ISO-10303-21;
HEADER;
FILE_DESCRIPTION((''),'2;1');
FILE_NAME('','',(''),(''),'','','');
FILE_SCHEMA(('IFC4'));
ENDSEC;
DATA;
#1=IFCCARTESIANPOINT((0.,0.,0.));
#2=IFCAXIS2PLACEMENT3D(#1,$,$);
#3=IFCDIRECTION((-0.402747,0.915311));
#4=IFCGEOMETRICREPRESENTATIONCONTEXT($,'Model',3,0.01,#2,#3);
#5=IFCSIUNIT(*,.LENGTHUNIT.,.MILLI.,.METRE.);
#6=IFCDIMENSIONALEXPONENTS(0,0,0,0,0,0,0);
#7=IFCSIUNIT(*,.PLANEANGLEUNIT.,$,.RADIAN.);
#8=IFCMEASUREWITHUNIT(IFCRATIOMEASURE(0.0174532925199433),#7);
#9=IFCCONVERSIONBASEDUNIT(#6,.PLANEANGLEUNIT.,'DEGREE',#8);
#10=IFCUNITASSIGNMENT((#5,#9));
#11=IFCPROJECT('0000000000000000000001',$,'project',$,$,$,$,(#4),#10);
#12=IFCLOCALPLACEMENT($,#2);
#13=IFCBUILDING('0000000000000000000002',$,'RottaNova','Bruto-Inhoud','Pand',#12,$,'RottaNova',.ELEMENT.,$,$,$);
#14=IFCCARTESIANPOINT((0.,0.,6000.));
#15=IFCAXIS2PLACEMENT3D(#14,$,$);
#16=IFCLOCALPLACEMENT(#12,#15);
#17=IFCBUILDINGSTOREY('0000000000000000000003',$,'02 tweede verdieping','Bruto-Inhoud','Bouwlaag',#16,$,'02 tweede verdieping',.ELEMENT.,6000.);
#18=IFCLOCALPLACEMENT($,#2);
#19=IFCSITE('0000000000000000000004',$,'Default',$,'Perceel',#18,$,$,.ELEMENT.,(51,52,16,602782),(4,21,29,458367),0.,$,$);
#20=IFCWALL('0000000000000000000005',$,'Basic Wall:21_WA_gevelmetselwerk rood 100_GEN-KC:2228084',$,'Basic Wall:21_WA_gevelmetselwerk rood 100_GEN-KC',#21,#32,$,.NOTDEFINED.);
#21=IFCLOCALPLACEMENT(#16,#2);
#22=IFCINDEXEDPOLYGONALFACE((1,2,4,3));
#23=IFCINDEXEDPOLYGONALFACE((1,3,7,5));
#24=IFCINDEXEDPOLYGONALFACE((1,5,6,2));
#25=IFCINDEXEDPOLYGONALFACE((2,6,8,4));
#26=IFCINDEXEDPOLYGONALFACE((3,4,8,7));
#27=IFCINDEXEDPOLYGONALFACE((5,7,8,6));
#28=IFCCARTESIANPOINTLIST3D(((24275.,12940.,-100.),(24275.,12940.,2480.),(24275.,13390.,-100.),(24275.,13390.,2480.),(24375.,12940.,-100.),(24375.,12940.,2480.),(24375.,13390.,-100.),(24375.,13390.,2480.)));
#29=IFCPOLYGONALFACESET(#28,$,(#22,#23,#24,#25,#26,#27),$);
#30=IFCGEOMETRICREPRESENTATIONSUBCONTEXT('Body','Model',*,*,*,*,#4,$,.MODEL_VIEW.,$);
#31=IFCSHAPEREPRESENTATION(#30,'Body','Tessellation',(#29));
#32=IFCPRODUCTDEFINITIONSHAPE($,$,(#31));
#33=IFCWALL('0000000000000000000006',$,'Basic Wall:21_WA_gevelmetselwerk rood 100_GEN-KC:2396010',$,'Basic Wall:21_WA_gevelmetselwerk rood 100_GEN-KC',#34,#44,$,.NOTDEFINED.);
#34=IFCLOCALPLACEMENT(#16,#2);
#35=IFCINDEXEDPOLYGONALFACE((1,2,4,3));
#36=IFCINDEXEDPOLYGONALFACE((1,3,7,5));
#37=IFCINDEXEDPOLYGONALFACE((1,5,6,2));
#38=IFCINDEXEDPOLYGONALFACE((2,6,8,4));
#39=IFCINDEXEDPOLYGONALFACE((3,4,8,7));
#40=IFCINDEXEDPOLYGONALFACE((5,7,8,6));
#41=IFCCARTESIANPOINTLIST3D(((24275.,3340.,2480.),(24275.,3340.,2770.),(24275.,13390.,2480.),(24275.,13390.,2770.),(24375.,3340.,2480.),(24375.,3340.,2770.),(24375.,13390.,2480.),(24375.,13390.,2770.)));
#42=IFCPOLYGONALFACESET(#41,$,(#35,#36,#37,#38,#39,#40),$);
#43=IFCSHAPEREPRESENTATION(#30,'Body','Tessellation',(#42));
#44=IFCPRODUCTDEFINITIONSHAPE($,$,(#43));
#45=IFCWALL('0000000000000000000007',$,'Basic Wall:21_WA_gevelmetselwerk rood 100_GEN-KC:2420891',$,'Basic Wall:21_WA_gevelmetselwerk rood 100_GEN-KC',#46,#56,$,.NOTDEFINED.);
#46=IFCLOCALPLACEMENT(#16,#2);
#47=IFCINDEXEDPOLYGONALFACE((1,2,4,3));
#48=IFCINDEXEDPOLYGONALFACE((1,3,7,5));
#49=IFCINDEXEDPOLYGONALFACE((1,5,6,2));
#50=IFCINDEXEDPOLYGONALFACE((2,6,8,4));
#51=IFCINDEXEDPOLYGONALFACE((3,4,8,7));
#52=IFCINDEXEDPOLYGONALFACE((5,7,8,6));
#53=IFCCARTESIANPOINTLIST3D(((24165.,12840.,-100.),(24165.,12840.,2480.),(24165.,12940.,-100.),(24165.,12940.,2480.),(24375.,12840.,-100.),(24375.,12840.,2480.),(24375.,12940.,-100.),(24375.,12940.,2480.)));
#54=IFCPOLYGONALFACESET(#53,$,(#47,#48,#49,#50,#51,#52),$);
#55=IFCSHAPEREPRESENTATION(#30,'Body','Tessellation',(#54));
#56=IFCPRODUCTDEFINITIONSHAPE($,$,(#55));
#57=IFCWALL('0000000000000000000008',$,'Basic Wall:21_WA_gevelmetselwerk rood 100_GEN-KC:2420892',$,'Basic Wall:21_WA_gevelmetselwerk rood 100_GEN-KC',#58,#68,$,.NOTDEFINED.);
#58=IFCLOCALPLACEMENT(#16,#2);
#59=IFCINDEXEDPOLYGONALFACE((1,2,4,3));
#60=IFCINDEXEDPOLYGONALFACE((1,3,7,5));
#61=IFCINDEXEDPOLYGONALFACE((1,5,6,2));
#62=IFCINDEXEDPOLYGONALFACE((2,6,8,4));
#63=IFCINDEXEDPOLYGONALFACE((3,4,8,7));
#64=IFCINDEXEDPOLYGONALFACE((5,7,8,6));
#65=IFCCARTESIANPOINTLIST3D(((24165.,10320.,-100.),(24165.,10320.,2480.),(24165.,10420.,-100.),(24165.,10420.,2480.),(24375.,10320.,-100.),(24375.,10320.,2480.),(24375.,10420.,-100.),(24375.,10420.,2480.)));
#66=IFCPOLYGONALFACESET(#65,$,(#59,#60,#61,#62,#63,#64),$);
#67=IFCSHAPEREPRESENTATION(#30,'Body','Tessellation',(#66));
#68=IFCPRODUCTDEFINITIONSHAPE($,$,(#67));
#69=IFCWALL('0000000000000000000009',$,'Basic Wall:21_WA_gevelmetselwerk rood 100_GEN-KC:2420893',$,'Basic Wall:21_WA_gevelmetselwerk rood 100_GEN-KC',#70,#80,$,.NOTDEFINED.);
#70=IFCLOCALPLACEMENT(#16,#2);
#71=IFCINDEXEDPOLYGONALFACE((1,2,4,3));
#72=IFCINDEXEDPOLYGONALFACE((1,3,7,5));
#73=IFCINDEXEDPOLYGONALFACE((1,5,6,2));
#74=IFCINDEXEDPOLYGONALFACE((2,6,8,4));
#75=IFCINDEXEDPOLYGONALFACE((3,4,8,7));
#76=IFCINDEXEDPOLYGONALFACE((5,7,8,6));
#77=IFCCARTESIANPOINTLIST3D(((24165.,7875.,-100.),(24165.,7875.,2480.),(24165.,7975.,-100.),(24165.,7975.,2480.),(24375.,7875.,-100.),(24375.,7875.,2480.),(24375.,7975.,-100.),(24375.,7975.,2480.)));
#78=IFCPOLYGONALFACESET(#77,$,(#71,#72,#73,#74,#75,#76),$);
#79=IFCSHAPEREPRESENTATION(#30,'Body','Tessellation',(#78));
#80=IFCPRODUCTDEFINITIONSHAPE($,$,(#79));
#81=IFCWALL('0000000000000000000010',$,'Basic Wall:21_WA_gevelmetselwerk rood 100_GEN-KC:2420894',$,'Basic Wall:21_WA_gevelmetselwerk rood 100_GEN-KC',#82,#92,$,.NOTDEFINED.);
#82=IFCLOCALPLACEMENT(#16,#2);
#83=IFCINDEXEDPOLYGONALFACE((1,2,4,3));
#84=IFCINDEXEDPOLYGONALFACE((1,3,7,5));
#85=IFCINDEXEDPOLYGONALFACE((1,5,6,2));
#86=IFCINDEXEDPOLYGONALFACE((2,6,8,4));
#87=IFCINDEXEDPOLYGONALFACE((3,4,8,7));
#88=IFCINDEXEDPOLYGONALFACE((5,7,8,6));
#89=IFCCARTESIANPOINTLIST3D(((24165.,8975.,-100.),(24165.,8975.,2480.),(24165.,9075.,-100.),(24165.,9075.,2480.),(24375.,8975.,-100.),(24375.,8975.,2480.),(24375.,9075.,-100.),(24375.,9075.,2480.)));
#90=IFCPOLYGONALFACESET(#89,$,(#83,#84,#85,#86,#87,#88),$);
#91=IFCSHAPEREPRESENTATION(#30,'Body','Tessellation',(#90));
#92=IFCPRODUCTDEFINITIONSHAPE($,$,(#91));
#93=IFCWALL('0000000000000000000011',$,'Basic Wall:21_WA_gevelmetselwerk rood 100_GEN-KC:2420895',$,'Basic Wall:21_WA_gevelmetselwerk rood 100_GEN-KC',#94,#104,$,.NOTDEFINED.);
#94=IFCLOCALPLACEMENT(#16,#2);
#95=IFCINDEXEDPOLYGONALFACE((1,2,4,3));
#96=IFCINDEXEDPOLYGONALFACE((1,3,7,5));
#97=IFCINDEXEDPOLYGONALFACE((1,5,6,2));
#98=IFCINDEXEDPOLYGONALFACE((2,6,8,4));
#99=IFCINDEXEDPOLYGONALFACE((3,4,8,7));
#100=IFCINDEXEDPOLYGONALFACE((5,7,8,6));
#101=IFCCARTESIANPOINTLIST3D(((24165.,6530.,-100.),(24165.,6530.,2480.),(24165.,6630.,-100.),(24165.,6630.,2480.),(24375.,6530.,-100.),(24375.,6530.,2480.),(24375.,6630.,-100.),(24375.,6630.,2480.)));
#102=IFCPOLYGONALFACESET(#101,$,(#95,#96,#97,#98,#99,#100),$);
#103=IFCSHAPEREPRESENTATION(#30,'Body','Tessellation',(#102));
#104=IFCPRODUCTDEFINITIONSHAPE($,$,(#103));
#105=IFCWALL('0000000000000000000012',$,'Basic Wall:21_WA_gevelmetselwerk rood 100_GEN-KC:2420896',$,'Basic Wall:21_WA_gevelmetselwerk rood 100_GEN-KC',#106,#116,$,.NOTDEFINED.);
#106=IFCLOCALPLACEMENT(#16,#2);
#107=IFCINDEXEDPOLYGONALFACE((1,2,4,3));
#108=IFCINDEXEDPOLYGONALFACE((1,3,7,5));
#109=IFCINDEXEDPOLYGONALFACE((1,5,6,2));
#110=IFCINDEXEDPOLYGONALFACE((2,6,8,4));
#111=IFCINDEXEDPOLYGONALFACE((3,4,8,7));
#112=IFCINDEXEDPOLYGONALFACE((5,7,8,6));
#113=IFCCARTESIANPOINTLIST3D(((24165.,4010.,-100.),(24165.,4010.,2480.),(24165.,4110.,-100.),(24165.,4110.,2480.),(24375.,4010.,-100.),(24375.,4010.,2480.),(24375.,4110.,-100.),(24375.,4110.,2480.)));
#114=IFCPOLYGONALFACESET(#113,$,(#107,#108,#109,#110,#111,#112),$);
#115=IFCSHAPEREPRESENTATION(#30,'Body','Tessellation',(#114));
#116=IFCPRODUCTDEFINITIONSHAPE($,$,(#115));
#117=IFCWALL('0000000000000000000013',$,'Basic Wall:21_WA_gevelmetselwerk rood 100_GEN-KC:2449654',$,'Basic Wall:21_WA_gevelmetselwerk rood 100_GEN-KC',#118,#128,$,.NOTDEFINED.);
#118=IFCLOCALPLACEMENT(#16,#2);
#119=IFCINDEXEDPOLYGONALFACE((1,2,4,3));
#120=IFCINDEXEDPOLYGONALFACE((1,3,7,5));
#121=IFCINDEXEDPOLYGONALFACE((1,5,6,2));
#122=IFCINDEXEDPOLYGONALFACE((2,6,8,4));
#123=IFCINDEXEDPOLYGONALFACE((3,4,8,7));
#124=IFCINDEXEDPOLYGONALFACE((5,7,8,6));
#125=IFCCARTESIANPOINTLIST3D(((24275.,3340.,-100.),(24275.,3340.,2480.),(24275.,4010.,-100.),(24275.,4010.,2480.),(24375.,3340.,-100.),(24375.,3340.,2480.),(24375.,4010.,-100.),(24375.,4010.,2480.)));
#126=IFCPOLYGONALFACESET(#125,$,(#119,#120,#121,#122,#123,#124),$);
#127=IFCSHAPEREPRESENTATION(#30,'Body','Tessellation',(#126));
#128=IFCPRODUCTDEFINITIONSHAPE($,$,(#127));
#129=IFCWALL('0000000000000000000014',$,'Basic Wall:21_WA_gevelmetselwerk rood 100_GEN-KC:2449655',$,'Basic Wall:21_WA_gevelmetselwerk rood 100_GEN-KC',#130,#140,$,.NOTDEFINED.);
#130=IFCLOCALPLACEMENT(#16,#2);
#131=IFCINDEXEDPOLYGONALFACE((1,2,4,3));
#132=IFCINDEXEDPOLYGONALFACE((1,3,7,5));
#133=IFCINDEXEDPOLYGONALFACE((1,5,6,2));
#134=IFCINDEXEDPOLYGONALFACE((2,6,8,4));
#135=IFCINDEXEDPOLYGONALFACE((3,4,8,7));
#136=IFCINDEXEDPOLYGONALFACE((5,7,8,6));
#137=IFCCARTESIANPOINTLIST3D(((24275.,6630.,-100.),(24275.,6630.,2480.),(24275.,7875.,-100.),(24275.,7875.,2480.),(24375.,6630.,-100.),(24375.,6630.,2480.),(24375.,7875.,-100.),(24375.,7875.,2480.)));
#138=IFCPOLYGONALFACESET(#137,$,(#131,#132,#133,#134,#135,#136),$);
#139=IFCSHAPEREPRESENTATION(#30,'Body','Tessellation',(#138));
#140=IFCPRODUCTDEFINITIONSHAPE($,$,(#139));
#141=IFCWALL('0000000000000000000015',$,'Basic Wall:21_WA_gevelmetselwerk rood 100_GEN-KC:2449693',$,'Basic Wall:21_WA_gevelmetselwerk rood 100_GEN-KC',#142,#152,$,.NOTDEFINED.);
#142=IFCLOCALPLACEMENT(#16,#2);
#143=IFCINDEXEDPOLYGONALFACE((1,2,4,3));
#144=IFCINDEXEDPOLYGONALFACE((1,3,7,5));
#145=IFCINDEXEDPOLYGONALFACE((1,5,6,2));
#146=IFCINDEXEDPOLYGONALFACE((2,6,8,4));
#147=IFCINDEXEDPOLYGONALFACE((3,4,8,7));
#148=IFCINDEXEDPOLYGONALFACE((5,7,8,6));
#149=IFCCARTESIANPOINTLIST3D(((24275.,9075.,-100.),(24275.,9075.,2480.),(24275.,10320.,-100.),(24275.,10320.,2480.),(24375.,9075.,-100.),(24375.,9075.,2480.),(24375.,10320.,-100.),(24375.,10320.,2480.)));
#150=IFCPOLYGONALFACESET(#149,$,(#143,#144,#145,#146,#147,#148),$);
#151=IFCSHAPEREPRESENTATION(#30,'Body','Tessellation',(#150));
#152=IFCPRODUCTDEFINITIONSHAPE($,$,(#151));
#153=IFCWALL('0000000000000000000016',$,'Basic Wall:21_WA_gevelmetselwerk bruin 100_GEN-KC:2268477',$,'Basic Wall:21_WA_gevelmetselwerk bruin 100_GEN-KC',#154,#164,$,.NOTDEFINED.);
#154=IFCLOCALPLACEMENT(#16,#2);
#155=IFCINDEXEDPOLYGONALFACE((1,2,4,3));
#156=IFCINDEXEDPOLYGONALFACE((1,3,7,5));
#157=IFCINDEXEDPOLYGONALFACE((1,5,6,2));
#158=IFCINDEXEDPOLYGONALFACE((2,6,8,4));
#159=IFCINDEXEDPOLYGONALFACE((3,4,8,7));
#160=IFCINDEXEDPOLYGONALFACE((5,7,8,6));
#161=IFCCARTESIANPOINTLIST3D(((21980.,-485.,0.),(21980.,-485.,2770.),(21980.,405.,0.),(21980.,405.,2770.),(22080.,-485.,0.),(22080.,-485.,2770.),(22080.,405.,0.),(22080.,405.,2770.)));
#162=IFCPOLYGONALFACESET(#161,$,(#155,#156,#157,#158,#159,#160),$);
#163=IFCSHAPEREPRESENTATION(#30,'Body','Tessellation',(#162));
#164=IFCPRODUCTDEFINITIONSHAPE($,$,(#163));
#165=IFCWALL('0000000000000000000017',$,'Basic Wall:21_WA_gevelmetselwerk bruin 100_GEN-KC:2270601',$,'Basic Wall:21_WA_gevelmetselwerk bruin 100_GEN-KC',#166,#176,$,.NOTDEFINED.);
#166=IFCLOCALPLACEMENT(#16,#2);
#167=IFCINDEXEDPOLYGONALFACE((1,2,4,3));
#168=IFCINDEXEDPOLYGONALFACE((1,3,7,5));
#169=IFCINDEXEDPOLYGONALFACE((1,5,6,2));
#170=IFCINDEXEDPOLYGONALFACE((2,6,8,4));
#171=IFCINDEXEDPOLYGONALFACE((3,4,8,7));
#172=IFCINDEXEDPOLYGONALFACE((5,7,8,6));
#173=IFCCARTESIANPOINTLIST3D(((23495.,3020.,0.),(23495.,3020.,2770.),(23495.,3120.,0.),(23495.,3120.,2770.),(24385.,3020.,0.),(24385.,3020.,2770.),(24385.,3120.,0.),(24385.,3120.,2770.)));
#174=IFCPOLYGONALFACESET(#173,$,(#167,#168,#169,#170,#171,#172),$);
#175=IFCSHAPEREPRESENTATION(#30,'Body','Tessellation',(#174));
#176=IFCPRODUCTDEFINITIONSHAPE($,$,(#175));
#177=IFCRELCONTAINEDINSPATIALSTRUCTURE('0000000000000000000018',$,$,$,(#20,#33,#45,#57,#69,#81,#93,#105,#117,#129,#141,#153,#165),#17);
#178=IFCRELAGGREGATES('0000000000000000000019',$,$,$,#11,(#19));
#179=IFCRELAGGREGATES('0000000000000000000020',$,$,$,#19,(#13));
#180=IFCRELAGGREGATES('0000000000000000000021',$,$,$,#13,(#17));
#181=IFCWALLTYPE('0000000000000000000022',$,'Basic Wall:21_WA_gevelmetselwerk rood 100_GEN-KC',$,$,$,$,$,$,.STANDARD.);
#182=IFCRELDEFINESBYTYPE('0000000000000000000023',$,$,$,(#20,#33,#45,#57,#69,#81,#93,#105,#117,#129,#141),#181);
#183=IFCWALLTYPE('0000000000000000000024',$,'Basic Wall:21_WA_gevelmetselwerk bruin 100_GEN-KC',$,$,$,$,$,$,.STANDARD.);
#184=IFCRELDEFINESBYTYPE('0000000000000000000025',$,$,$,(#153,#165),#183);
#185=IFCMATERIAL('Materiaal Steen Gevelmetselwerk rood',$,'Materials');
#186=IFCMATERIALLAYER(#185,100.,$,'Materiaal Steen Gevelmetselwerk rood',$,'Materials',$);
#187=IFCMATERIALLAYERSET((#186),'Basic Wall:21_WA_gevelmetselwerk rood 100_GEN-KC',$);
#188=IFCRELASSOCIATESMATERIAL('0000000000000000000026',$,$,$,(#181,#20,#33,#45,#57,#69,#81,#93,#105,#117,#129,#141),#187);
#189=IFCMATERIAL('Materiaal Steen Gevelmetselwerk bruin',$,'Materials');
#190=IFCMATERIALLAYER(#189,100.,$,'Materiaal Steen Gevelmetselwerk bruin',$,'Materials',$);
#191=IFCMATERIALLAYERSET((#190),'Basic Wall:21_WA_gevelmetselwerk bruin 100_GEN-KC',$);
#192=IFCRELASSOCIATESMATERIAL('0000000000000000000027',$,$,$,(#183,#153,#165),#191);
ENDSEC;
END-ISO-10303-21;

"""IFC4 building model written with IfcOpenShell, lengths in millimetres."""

from ifc_helpers import new_model, entity, si_unit, converted_unit, direction, frame, frame_2d, origin, place, context, subcontext, project, spatial, rectangle, extrude, material, layer, layer_set, type_object, element, save


model = new_model("IFC4")

# Units and contexts
model_context = context("Model", 3, precision=0.01, world=origin(), true_north=direction((-0.402747, 0.915311)))
body_context = subcontext(model_context, "Body", "Model", "MODEL_VIEW")
ifc_project = project(units=[si_unit("LENGTHUNIT", "METRE", prefix="MILLI"), converted_unit("PLANEANGLEUNIT", "DEGREE", entity("IfcRatioMeasure", 0.0174532925199433), si_unit("PLANEANGLEUNIT", "RADIAN"), dimensions=[0, 0, 0, 0, 0, 0, 0])], contexts=[model_context])

# Site, building, storey
site_placement = place(None, origin())
site = spatial("IfcSite", under=ifc_project, at=site_placement, Name="Default", ObjectType="Perceel", CompositionType="ELEMENT", RefLatitude=(51, 52, 16, 602782), RefLongitude=(4, 21, 29, 458367), RefElevation=0.0)
building_placement = place(None, origin())
building = spatial("IfcBuilding", under=site, at=building_placement, Name="RottaNova", Description="Bruto-Inhoud", ObjectType="Pand", LongName="RottaNova", CompositionType="ELEMENT")
storey_placement = place(building_placement, frame((0.0, 0.0, 6000.0)))
storey = spatial("IfcBuildingStorey", under=building, at=storey_placement, Name="02 tweede verdieping", Description="Bruto-Inhoud", ObjectType="Bouwlaag", LongName="02 tweede verdieping", CompositionType="ELEMENT", Elevation=6000.0)

# Walls
ifc_material_1 = material(Name="Materiaal Steen Gevelmetselwerk rood", Category="Materials")
ifc_layer_1 = layer(ifc_material_1, 100.0, Name="Materiaal Steen Gevelmetselwerk rood", Category="Materials")
ifc_layer_set_1 = layer_set([ifc_layer_1], Name="Basic Wall:21_WA_gevelmetselwerk rood 100_GEN-KC")
wall_type_1 = type_object("IfcWallType", Name="Basic Wall:21_WA_gevelmetselwerk rood 100_GEN-KC", PredefinedType="STANDARD", material=ifc_layer_set_1)
wall_1_placement = place(storey_placement, frame((24325.0, 13390.0, -100.0), z_axis=(0.0, 0.0, 1.0), x_axis=(0.0, -1.0, 0.0)))
element("IfcWall", 1, at=wall_1_placement, inside=storey, type_object=wall_type_1, material=ifc_layer_set_1, Name="Basic Wall:21_WA_gevelmetselwerk rood 100_GEN-KC:2228084", ObjectType="Basic Wall:21_WA_gevelmetselwerk rood 100_GEN-KC", PredefinedType="NOTDEFINED", context=body_context, shape_type="SweptSolid", body=[
    extrude(rectangle(XDim=450.0, YDim=100.0, at=frame_2d((225.0, 0.0), x_axis=(-1.0, 0.0))), origin(), (0.0, 0.0, 1.0), 2580.0),
])
wall_2_placement = place(storey_placement, frame((24325.0, 13390.0, 2480.0), z_axis=(0.0, 0.0, 1.0), x_axis=(0.0, -1.0, 0.0)))
element("IfcWall", 2, at=wall_2_placement, inside=storey, type_object=wall_type_1, material=ifc_layer_set_1, Name="Basic Wall:21_WA_gevelmetselwerk rood 100_GEN-KC:2396010", ObjectType="Basic Wall:21_WA_gevelmetselwerk rood 100_GEN-KC", PredefinedType="NOTDEFINED", context=body_context, shape_type="SweptSolid", body=[
    extrude(rectangle(XDim=10050.0, YDim=100.0, at=frame_2d((5025.0, 0.0), x_axis=(-1.0, 0.0))), origin(), (0.0, 0.0, 1.0), 290.0),
])
wall_3_placement = place(storey_placement, frame((24375.0, 12890.0, -100.0), z_axis=(0.0, 0.0, 1.0), x_axis=(-1.0, 0.0, 0.0)))
element("IfcWall", 3, at=wall_3_placement, inside=storey, type_object=wall_type_1, material=ifc_layer_set_1, Name="Basic Wall:21_WA_gevelmetselwerk rood 100_GEN-KC:2420891", ObjectType="Basic Wall:21_WA_gevelmetselwerk rood 100_GEN-KC", PredefinedType="NOTDEFINED", context=body_context, shape_type="SweptSolid", body=[
    extrude(rectangle(XDim=210.0, YDim=100.0, at=frame_2d((105.0, 0.0), x_axis=(-1.0, 0.0))), origin(), (0.0, 0.0, 1.0), 2580.0),
])
wall_4_placement = place(storey_placement, frame((24375.0, 10370.0, -100.0), z_axis=(0.0, 0.0, 1.0), x_axis=(-1.0, 0.0, 0.0)))
element("IfcWall", 4, at=wall_4_placement, inside=storey, type_object=wall_type_1, material=ifc_layer_set_1, Name="Basic Wall:21_WA_gevelmetselwerk rood 100_GEN-KC:2420892", ObjectType="Basic Wall:21_WA_gevelmetselwerk rood 100_GEN-KC", PredefinedType="NOTDEFINED", context=body_context, shape_type="SweptSolid", body=[
    extrude(rectangle(XDim=210.0, YDim=100.0, at=frame_2d((105.0, 0.0), x_axis=(-1.0, 0.0))), origin(), (0.0, 0.0, 1.0), 2580.0),
])
wall_5_placement = place(storey_placement, frame((24375.0, 7925.0, -100.0), z_axis=(0.0, 0.0, 1.0), x_axis=(-1.0, 0.0, 0.0)))
element("IfcWall", 5, at=wall_5_placement, inside=storey, type_object=wall_type_1, material=ifc_layer_set_1, Name="Basic Wall:21_WA_gevelmetselwerk rood 100_GEN-KC:2420893", ObjectType="Basic Wall:21_WA_gevelmetselwerk rood 100_GEN-KC", PredefinedType="NOTDEFINED", context=body_context, shape_type="SweptSolid", body=[
    extrude(rectangle(XDim=210.0, YDim=100.0, at=frame_2d((105.0, 0.0), x_axis=(-1.0, 0.0))), origin(), (0.0, 0.0, 1.0), 2580.0),
])
wall_6_placement = place(storey_placement, frame((24375.0, 9025.0, -100.0), z_axis=(0.0, 0.0, 1.0), x_axis=(-1.0, 0.0, 0.0)))
element("IfcWall", 6, at=wall_6_placement, inside=storey, type_object=wall_type_1, material=ifc_layer_set_1, Name="Basic Wall:21_WA_gevelmetselwerk rood 100_GEN-KC:2420894", ObjectType="Basic Wall:21_WA_gevelmetselwerk rood 100_GEN-KC", PredefinedType="NOTDEFINED", context=body_context, shape_type="SweptSolid", body=[
    extrude(rectangle(XDim=210.0, YDim=100.0, at=frame_2d((105.0, 0.0), x_axis=(-1.0, 0.0))), origin(), (0.0, 0.0, 1.0), 2580.0),
])
wall_7_placement = place(storey_placement, frame((24375.0, 6580.0, -100.0), z_axis=(0.0, 0.0, 1.0), x_axis=(-1.0, 0.0, 0.0)))
element("IfcWall", 7, at=wall_7_placement, inside=storey, type_object=wall_type_1, material=ifc_layer_set_1, Name="Basic Wall:21_WA_gevelmetselwerk rood 100_GEN-KC:2420895", ObjectType="Basic Wall:21_WA_gevelmetselwerk rood 100_GEN-KC", PredefinedType="NOTDEFINED", context=body_context, shape_type="SweptSolid", body=[
    extrude(rectangle(XDim=210.0, YDim=100.0, at=frame_2d((105.0, 0.0), x_axis=(-1.0, 0.0))), origin(), (0.0, 0.0, 1.0), 2580.0),
])
wall_8_placement = place(storey_placement, frame((24375.0, 4060.0, -100.0), z_axis=(0.0, 0.0, 1.0), x_axis=(-1.0, 0.0, 0.0)))
element("IfcWall", 8, at=wall_8_placement, inside=storey, type_object=wall_type_1, material=ifc_layer_set_1, Name="Basic Wall:21_WA_gevelmetselwerk rood 100_GEN-KC:2420896", ObjectType="Basic Wall:21_WA_gevelmetselwerk rood 100_GEN-KC", PredefinedType="NOTDEFINED", context=body_context, shape_type="SweptSolid", body=[
    extrude(rectangle(XDim=210.0, YDim=100.0, at=frame_2d((105.0, 0.0), x_axis=(-1.0, 0.0))), origin(), (0.0, 0.0, 1.0), 2580.0),
])
wall_9_placement = place(storey_placement, frame((24325.0, 4010.0, -100.0), z_axis=(0.0, 0.0, 1.0), x_axis=(0.0, -1.0, 0.0)))
element("IfcWall", 9, at=wall_9_placement, inside=storey, type_object=wall_type_1, material=ifc_layer_set_1, Name="Basic Wall:21_WA_gevelmetselwerk rood 100_GEN-KC:2449654", ObjectType="Basic Wall:21_WA_gevelmetselwerk rood 100_GEN-KC", PredefinedType="NOTDEFINED", context=body_context, shape_type="SweptSolid", body=[
    extrude(rectangle(XDim=670.0, YDim=100.0, at=frame_2d((335.0, 0.0), x_axis=(-1.0, 0.0))), origin(), (0.0, 0.0, 1.0), 2580.0),
])
wall_10_placement = place(storey_placement, frame((24325.0, 7875.0, -100.0), z_axis=(0.0, 0.0, 1.0), x_axis=(0.0, -1.0, 0.0)))
element("IfcWall", 10, at=wall_10_placement, inside=storey, type_object=wall_type_1, material=ifc_layer_set_1, Name="Basic Wall:21_WA_gevelmetselwerk rood 100_GEN-KC:2449655", ObjectType="Basic Wall:21_WA_gevelmetselwerk rood 100_GEN-KC", PredefinedType="NOTDEFINED", context=body_context, shape_type="SweptSolid", body=[
    extrude(rectangle(XDim=1245.0, YDim=100.0, at=frame_2d((622.5, 0.0), x_axis=(-1.0, 0.0))), origin(), (0.0, 0.0, 1.0), 2580.0),
])
wall_11_placement = place(storey_placement, frame((24325.0, 10320.0, -100.0), z_axis=(0.0, 0.0, 1.0), x_axis=(0.0, -1.0, 0.0)))
element("IfcWall", 11, at=wall_11_placement, inside=storey, type_object=wall_type_1, material=ifc_layer_set_1, Name="Basic Wall:21_WA_gevelmetselwerk rood 100_GEN-KC:2449693", ObjectType="Basic Wall:21_WA_gevelmetselwerk rood 100_GEN-KC", PredefinedType="NOTDEFINED", context=body_context, shape_type="SweptSolid", body=[
    extrude(rectangle(XDim=1245.0, YDim=100.0, at=frame_2d((622.5, 0.0), x_axis=(-1.0, 0.0))), origin(), (0.0, 0.0, 1.0), 2580.0),
])
ifc_material_2 = material(Name="Materiaal Steen Gevelmetselwerk bruin", Category="Materials")
ifc_layer_2 = layer(ifc_material_2, 100.0, Name="Materiaal Steen Gevelmetselwerk bruin", Category="Materials")
ifc_layer_set_2 = layer_set([ifc_layer_2], Name="Basic Wall:21_WA_gevelmetselwerk bruin 100_GEN-KC")
wall_type_2 = type_object("IfcWallType", Name="Basic Wall:21_WA_gevelmetselwerk bruin 100_GEN-KC", PredefinedType="STANDARD", material=ifc_layer_set_2)
wall_12_placement = place(storey_placement, frame((22030.0, 405.0, 0.0), z_axis=(0.0, 0.0, 1.0), x_axis=(0.0, -1.0, 0.0)))
element("IfcWall", 12, at=wall_12_placement, inside=storey, type_object=wall_type_2, material=ifc_layer_set_2, Name="Basic Wall:21_WA_gevelmetselwerk bruin 100_GEN-KC:2268477", ObjectType="Basic Wall:21_WA_gevelmetselwerk bruin 100_GEN-KC", PredefinedType="NOTDEFINED", context=body_context, shape_type="SweptSolid", body=[
    extrude(rectangle(XDim=890.0, YDim=100.0, at=frame_2d((445.0, 0.0), x_axis=(-1.0, 0.0))), origin(), (0.0, 0.0, 1.0), 2770.0),
])
wall_13_placement = place(storey_placement, frame((24385.0, 3070.0, 0.0), z_axis=(0.0, 0.0, 1.0), x_axis=(-1.0, 0.0, 0.0)))
element("IfcWall", 13, at=wall_13_placement, inside=storey, type_object=wall_type_2, material=ifc_layer_set_2, Name="Basic Wall:21_WA_gevelmetselwerk bruin 100_GEN-KC:2270601", ObjectType="Basic Wall:21_WA_gevelmetselwerk bruin 100_GEN-KC", PredefinedType="NOTDEFINED", context=body_context, shape_type="SweptSolid", body=[
    extrude(rectangle(XDim=890.0, YDim=100.0, at=frame_2d((445.0, 0.0), x_axis=(-1.0, 0.0))), origin(), (0.0, 0.0, 1.0), 2770.0),
])

save(model, "model.ifc")
